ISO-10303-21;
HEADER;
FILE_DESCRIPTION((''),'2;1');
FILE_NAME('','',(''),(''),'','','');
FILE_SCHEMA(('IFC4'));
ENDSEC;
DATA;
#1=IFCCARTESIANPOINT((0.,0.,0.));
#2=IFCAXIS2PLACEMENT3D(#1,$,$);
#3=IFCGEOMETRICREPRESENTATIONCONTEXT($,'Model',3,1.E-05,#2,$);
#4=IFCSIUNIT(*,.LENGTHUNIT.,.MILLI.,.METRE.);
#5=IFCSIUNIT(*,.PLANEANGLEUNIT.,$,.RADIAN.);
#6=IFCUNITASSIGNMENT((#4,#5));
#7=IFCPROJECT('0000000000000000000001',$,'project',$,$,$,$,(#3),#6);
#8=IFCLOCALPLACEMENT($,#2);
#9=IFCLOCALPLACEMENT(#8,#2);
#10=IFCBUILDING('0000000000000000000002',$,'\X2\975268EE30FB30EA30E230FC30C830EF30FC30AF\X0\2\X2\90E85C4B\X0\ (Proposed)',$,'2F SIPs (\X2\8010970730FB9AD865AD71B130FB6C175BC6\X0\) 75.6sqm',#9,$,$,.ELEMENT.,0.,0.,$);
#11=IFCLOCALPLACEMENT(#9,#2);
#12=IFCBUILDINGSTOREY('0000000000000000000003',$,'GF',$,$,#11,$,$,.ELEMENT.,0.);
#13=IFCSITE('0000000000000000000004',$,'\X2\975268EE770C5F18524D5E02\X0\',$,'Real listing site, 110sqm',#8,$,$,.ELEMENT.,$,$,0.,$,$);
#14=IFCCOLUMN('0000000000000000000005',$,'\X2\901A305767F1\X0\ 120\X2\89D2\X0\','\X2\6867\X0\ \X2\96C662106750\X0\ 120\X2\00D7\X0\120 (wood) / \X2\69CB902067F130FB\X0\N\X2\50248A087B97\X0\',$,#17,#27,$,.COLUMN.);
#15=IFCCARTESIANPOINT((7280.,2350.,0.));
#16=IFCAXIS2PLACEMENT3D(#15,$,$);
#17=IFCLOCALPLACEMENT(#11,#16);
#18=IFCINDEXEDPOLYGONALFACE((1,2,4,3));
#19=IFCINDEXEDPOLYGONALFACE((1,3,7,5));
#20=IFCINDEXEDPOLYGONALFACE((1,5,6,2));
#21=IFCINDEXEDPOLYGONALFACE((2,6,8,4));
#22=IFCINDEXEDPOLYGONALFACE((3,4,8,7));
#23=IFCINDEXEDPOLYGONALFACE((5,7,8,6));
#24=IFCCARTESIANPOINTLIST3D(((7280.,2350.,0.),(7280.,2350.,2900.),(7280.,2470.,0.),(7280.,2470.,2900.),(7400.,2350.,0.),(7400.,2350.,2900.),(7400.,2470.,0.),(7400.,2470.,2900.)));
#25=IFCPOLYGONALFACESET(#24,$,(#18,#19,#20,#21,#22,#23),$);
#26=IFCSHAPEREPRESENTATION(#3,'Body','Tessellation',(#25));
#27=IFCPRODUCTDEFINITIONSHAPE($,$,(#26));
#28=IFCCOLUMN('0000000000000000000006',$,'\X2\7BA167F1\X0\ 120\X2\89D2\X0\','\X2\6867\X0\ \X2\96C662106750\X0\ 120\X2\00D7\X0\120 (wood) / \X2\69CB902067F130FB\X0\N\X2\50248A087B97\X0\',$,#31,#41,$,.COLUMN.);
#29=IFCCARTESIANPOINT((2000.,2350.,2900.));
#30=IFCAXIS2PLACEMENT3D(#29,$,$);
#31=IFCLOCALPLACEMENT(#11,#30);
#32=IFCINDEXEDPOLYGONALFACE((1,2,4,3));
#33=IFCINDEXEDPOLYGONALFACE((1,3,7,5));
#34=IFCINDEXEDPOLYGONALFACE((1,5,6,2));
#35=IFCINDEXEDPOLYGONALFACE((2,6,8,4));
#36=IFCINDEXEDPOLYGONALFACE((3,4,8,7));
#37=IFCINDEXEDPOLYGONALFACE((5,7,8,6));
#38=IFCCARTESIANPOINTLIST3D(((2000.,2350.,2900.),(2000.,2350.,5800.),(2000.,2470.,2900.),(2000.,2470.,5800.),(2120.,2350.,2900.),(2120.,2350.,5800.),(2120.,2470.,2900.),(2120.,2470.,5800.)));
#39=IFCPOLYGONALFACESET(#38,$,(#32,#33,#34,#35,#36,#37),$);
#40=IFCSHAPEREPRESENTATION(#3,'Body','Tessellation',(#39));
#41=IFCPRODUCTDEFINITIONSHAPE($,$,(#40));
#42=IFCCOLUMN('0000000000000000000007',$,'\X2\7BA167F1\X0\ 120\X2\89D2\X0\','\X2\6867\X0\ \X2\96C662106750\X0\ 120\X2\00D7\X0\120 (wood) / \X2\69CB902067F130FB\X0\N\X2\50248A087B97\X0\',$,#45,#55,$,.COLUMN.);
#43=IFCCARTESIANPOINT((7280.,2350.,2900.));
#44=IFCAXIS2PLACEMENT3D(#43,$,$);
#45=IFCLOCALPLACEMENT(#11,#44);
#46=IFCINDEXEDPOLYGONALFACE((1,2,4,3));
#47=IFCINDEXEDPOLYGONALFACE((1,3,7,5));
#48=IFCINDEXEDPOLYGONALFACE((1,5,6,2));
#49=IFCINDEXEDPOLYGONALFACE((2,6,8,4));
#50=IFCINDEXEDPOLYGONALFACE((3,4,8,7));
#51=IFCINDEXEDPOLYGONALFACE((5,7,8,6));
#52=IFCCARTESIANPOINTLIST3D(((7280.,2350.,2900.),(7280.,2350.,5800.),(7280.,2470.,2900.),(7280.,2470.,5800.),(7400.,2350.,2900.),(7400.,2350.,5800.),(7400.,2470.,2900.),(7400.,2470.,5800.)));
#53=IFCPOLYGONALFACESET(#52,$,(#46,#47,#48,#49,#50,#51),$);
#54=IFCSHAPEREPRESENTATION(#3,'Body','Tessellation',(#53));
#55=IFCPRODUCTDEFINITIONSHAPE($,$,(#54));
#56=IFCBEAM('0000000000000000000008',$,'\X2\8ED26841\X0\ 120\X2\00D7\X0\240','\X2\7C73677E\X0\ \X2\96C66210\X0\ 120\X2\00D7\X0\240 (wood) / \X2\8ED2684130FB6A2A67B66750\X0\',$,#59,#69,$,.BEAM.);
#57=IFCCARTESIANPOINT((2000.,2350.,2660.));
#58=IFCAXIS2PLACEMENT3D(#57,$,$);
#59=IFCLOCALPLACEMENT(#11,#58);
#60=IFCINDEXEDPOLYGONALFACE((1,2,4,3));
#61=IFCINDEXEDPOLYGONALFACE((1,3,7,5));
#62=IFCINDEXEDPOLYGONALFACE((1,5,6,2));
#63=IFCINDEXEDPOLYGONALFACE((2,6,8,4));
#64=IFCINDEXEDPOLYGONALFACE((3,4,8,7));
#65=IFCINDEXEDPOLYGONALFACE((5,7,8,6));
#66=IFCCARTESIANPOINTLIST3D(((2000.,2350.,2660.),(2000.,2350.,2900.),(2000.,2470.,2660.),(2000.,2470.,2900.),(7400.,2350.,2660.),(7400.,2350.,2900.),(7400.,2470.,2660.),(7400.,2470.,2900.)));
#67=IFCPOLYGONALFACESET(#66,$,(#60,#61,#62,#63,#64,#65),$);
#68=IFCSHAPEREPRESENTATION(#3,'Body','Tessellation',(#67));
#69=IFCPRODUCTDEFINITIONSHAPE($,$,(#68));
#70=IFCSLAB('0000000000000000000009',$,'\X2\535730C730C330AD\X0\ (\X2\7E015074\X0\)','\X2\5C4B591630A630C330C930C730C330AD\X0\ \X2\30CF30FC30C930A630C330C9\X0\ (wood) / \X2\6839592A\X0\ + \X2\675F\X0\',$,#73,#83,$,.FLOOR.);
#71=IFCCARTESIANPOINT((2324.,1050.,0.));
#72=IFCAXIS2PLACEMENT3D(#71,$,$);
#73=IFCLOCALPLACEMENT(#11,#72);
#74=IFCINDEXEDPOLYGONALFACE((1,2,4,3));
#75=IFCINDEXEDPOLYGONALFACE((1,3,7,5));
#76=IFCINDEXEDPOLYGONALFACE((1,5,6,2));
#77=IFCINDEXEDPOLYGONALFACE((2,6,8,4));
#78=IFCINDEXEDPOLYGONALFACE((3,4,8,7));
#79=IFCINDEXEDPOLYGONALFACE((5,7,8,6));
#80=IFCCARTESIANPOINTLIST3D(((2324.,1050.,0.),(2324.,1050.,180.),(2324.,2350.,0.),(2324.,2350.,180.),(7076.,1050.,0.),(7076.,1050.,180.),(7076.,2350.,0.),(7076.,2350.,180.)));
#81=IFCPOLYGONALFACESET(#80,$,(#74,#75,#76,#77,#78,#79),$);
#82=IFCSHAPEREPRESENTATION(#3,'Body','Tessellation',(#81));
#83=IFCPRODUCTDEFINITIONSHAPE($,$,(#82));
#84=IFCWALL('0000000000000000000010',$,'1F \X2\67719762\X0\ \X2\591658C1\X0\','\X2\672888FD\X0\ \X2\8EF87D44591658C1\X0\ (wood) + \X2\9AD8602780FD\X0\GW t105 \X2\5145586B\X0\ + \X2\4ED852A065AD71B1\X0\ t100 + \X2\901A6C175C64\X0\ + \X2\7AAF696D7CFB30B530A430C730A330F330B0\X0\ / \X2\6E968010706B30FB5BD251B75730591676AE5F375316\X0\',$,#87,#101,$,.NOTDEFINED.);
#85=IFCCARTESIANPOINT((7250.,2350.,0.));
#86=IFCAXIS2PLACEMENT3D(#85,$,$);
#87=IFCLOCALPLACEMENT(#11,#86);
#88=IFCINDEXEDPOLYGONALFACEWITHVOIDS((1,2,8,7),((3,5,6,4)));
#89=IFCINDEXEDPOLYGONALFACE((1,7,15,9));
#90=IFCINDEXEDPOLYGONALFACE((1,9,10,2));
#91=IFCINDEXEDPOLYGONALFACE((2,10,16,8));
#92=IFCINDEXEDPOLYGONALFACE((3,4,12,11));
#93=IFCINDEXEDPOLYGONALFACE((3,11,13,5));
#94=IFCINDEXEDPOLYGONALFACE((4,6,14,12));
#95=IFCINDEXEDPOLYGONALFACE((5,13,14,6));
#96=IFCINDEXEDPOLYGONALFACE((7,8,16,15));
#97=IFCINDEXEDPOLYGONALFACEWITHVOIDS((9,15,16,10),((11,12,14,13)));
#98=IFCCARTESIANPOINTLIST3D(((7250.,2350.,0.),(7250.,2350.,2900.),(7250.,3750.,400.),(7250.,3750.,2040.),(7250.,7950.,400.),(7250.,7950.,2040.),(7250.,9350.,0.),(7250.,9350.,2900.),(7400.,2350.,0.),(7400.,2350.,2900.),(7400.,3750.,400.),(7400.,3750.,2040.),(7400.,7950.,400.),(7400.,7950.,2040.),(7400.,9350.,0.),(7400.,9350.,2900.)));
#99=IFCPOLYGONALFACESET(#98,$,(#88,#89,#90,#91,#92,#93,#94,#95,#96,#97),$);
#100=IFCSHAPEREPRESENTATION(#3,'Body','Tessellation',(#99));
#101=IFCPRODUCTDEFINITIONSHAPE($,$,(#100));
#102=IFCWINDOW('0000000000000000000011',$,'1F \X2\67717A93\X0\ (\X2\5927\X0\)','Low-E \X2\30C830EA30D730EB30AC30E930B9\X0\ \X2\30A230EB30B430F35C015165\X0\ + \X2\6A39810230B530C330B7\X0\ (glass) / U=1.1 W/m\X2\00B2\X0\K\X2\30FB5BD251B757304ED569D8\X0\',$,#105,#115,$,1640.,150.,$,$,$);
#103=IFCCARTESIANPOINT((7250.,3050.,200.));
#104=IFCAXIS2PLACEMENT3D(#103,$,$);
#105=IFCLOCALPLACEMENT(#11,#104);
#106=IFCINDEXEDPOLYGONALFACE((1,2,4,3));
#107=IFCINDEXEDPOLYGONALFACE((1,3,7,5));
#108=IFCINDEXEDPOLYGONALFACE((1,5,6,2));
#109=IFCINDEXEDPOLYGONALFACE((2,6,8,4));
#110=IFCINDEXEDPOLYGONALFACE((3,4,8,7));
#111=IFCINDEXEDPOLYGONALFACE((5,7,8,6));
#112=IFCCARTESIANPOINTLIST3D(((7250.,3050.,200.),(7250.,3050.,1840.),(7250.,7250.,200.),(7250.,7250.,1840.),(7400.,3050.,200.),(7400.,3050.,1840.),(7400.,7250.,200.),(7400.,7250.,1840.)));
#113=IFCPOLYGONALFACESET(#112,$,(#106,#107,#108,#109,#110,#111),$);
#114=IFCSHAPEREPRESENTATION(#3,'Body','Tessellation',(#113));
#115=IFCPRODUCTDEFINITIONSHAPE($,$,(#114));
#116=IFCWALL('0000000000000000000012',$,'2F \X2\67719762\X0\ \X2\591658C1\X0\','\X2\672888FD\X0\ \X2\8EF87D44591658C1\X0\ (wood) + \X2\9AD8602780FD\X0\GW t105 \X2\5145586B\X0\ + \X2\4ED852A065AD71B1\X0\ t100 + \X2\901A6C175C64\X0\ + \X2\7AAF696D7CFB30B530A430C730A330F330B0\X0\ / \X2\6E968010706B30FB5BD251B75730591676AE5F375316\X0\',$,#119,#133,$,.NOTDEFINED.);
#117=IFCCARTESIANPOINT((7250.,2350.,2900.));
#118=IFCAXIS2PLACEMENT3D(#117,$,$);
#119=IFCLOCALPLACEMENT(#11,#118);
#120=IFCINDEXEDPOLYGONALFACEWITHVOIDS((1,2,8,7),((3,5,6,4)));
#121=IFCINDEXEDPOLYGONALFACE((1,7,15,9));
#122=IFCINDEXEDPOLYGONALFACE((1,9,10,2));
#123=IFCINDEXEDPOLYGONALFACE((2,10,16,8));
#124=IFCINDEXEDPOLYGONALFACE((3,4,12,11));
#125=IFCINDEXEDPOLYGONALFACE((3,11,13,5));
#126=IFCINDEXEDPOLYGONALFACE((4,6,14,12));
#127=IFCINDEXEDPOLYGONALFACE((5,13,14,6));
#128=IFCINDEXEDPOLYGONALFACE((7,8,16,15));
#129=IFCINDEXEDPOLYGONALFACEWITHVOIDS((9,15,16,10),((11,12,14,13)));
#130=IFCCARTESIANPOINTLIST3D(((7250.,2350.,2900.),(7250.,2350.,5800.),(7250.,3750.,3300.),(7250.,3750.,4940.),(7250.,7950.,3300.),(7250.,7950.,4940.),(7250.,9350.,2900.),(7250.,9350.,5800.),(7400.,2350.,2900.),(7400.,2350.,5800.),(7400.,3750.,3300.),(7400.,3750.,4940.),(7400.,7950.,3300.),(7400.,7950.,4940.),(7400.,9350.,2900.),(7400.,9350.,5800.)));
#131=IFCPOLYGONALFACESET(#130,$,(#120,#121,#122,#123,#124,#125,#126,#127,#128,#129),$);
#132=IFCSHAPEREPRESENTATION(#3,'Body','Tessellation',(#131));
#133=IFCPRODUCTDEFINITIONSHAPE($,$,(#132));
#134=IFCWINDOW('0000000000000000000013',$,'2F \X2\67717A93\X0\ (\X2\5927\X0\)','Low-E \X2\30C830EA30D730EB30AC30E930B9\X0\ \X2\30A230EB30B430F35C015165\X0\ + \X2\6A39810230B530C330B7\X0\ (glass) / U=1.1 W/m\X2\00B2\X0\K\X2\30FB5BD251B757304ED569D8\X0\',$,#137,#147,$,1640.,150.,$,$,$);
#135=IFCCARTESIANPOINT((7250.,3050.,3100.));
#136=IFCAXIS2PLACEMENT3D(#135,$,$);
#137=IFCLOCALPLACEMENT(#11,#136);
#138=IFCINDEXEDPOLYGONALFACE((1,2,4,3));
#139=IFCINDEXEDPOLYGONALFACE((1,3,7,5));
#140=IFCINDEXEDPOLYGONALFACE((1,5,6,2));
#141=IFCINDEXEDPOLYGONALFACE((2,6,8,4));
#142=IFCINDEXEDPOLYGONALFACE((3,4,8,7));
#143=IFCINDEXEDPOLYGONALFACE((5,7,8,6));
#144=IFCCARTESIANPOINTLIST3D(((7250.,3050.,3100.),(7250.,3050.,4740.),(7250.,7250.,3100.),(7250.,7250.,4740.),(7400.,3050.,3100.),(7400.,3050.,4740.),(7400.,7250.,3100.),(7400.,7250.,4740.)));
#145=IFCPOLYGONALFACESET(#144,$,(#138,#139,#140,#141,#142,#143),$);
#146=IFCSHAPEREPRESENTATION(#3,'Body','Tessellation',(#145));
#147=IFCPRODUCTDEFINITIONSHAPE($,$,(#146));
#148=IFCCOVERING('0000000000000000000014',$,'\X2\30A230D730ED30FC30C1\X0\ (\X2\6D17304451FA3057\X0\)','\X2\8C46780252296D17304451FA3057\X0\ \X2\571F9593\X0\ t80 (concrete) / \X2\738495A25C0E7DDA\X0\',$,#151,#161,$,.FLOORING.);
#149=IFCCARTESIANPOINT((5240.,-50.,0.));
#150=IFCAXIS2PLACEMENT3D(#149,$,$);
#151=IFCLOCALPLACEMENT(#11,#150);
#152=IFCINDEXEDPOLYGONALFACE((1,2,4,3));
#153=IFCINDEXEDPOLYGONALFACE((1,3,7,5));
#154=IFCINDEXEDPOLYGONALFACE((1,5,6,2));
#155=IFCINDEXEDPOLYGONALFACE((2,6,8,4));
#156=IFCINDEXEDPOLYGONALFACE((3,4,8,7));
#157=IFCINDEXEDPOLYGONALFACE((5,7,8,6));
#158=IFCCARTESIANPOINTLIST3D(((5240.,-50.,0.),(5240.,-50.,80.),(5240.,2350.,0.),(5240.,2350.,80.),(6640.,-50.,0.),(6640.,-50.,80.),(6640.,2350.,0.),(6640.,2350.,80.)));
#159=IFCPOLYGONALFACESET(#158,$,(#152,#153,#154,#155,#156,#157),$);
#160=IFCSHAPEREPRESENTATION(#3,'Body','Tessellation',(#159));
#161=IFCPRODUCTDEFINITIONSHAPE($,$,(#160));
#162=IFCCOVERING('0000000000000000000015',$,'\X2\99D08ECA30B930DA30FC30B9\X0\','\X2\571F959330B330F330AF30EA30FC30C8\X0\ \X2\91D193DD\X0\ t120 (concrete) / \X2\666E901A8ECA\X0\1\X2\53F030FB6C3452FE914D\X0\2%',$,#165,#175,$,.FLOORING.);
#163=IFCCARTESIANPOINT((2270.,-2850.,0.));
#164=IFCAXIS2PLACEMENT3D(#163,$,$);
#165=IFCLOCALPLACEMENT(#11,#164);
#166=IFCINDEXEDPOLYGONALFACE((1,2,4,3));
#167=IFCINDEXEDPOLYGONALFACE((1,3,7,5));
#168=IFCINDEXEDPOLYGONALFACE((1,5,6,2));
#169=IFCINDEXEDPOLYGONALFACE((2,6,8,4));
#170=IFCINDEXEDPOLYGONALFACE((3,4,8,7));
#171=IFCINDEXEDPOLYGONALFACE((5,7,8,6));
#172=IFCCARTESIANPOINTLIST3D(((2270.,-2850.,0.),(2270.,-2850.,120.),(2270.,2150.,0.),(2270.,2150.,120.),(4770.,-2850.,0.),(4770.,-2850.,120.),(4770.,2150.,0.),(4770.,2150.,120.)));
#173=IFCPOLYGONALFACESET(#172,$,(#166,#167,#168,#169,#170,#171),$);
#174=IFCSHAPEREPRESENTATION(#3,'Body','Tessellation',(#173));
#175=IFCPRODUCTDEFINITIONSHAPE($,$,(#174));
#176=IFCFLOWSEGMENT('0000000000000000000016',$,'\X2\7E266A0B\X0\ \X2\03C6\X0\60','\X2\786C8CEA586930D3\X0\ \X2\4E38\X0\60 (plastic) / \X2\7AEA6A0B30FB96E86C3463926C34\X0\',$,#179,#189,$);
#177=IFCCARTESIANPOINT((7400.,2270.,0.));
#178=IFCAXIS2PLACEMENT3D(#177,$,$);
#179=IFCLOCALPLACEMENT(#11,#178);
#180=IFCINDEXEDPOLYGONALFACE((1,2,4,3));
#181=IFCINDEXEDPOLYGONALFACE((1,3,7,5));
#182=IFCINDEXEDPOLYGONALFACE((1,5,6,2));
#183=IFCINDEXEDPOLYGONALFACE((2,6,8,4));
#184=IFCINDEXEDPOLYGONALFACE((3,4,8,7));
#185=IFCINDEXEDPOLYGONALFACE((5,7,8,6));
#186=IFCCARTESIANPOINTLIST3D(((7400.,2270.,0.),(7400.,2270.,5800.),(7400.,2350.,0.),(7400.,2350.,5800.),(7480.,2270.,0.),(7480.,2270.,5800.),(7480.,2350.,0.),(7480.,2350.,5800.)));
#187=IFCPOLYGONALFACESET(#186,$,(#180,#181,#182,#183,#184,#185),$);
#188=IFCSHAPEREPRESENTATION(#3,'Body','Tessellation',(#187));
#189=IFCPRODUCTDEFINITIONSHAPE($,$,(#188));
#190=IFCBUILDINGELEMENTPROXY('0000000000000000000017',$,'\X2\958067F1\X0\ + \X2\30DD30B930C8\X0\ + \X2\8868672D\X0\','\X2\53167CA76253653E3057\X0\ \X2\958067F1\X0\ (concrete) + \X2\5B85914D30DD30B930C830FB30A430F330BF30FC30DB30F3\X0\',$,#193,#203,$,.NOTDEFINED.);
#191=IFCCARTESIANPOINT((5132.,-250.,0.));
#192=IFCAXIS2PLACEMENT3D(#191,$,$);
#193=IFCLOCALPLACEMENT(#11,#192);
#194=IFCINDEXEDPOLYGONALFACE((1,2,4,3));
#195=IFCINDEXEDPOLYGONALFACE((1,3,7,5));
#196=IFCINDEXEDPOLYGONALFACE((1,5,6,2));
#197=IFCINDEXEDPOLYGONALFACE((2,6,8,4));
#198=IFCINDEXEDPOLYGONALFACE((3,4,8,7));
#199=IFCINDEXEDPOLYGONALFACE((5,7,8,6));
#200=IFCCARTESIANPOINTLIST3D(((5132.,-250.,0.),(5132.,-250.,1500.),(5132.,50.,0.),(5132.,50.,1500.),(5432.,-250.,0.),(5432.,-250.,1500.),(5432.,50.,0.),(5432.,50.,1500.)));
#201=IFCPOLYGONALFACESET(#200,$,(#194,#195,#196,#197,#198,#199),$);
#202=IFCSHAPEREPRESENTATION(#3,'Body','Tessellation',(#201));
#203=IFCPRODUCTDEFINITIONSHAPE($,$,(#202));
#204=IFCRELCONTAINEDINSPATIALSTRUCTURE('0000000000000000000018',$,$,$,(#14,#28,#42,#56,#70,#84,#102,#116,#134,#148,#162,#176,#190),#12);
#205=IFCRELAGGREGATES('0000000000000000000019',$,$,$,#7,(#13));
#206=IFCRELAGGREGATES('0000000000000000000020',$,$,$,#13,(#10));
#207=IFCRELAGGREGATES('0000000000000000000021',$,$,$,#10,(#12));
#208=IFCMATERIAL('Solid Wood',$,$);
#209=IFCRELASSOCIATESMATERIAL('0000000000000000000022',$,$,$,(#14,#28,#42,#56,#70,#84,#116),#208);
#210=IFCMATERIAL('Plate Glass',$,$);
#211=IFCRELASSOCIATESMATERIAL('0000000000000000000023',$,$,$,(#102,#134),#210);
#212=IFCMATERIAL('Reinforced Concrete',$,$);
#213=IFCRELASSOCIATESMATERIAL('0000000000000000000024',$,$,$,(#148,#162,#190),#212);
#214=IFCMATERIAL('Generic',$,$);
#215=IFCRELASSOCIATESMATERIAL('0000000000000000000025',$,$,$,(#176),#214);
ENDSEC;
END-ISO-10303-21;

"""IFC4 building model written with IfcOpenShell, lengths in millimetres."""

from ifc_helpers import new_model, si_unit, frame, frame_2d, origin, place, context, project, spatial, rectangle, extrude, material, element, fill, save


model = new_model("IFC4")

# Units and contexts
model_context = context("Model", 3, precision=1e-05, world=origin())
ifc_project = project(units=[si_unit("LENGTHUNIT", "METRE", prefix="MILLI"), si_unit("PLANEANGLEUNIT", "RADIAN")], contexts=[model_context])

# Site, building, storey
site_placement = place(None, origin())
site = spatial("IfcSite", under=ifc_project, at=site_placement, Name="青森県弘前市", ObjectType="Real listing site, 110sqm", CompositionType="ELEMENT", RefElevation=0.0)
building_placement = place(site_placement, origin())
building = spatial("IfcBuilding", under=site, at=building_placement, Name="青森・リモートワーク2部屋 (Proposed)", ObjectType="2F SIPs (耐震・高断熱・気密) 75.6sqm", CompositionType="ELEMENT", ElevationOfRefHeight=0.0, ElevationOfTerrain=0.0)
storey_placement = place(building_placement, origin())
storey = spatial("IfcBuildingStorey", under=building, at=storey_placement, Name="GF", CompositionType="ELEMENT", Elevation=0.0)

# Columns
ifc_material_1 = material(Name="Solid Wood")
column_1_placement = place(storey_placement, frame((7280.0, 2350.0, 0.0)))
element("IfcColumn", 1, at=column_1_placement, inside=storey, material=ifc_material_1, Name="通し柱 120角", Description="桧 集成材 120×120 (wood) / 構造柱・N値計算", PredefinedType="COLUMN", context=model_context, shape_type="SweptSolid", body=[
    extrude(rectangle(XDim=120.0, YDim=120.0, at=frame_2d((60.0, 60.0))), frame((7280.0, 2350.0, 0.0)), (0.0, 0.0, 1.0), 2900.0),
])
column_2_placement = place(storey_placement, frame((2000.0, 2350.0, 2900.0)))
element("IfcColumn", 2, at=column_2_placement, inside=storey, material=ifc_material_1, Name="管柱 120角", Description="桧 集成材 120×120 (wood) / 構造柱・N値計算", PredefinedType="COLUMN", context=model_context, shape_type="SweptSolid", body=[
    extrude(rectangle(XDim=120.0, YDim=120.0, at=frame_2d((60.0, 60.0))), frame((2000.0, 2350.0, 2900.0)), (0.0, 0.0, 1.0), 2900.0),
])
column_3_placement = place(storey_placement, frame((7280.0, 2350.0, 2900.0)))
element("IfcColumn", 3, at=column_3_placement, inside=storey, material=ifc_material_1, Name="管柱 120角", Description="桧 集成材 120×120 (wood) / 構造柱・N値計算", PredefinedType="COLUMN", context=model_context, shape_type="SweptSolid", body=[
    extrude(rectangle(XDim=120.0, YDim=120.0, at=frame_2d((60.0, 60.0))), frame((7280.0, 2350.0, 2900.0)), (0.0, 0.0, 1.0), 2900.0),
])

# Beam
beam_1_placement = place(storey_placement, frame((2000.0, 2350.0, 2660.0)))
element("IfcBeam", 4, at=beam_1_placement, inside=storey, material=ifc_material_1, Name="軒桁 120×240", Description="米松 集成 120×240 (wood) / 軒桁・横架材", PredefinedType="BEAM", context=model_context, shape_type="SweptSolid", body=[
    extrude(rectangle(XDim=5400.0, YDim=120.0, at=frame_2d((2700.0, 60.0))), frame((2000.0, 2350.0, 2660.0)), (0.0, 0.0, 1.0), 240.0),
])

# Slab
slab_placement = place(storey_placement, frame((2324.0, 1050.0, 0.0)))
element("IfcSlab", 5, at=slab_placement, inside=storey, material=ifc_material_1, Name="南デッキ (縁側)", Description="屋外ウッドデッキ ハードウッド (wood) / 根太 + 束", PredefinedType="FLOOR", context=model_context, shape_type="SweptSolid", body=[
    extrude(rectangle(XDim=4752.0, YDim=1300.0, at=frame_2d((2376.0, 650.0))), frame((2324.0, 1050.0, 0.0)), (0.0, 0.0, 1.0), 180.0),
])

# Walls, openings, windows
wall_1_placement = place(storey_placement, frame((7250.0, 2350.0, 0.0)))
wall_1 = element("IfcWall", 6, at=wall_1_placement, inside=storey, material=ifc_material_1, Name="1F 東面 外壁", Description="木製 軸組外壁 (wood) + 高性能GW t105 充填 + 付加断熱 t100 + 通気層 + 窯業系サイディング / 準耐火・寒冷地外皮強化", PredefinedType="NOTDEFINED", context=model_context, shape_type="SweptSolid", body=[
    extrude(rectangle(XDim=150.0, YDim=7000.0, at=frame_2d((75.0, 3500.0))), frame((7250.0, 2350.0, 0.0)), (0.0, 0.0, 1.0), 2900.0),
])
opening_1_placement = place(storey_placement, frame((7250.0, 3050.0, 200.0)))
opening_1 = element("IfcOpeningElement", 7, at=opening_1_placement, cuts=wall_1, PredefinedType="NOTDEFINED", context=model_context, shape_type="SweptSolid", body=[
    extrude(rectangle(XDim=150.0, YDim=4200.0, at=frame_2d((75.0, 2100.0))), frame((7250.0, 3050.0, 200.0)), (0.0, 0.0, 1.0), 1640.0),
])
ifc_material_2 = material(Name="Plate Glass")
window_1_placement = place(storey_placement, frame((7250.0, 3050.0, 200.0)))
window_1 = element("IfcWindow", 8, at=window_1_placement, inside=storey, material=ifc_material_2, Name="1F 東窓 (大)", Description="Low-E トリプルガラス アルゴン封入 + 樹脂サッシ (glass) / U=1.1 W/m²K・寒冷地仕様", OverallHeight=1640.0, OverallWidth=150.0, context=model_context, shape_type="SweptSolid", body=[
    extrude(rectangle(XDim=150.0, YDim=4200.0, at=frame_2d((75.0, 2100.0))), frame((7250.0, 3050.0, 200.0)), (0.0, 0.0, 1.0), 1640.0),
])
fill(opening_1, window_1)
wall_2_placement = place(storey_placement, frame((7250.0, 2350.0, 2900.0)))
wall_2 = element("IfcWall", 9, at=wall_2_placement, inside=storey, material=ifc_material_1, Name="2F 東面 外壁", Description="木製 軸組外壁 (wood) + 高性能GW t105 充填 + 付加断熱 t100 + 通気層 + 窯業系サイディング / 準耐火・寒冷地外皮強化", PredefinedType="NOTDEFINED", context=model_context, shape_type="SweptSolid", body=[
    extrude(rectangle(XDim=150.0, YDim=7000.0, at=frame_2d((75.0, 3500.0))), frame((7250.0, 2350.0, 2900.0)), (0.0, 0.0, 1.0), 2900.0),
])
opening_2_placement = place(storey_placement, frame((7250.0, 3050.0, 3100.0)))
opening_2 = element("IfcOpeningElement", 10, at=opening_2_placement, cuts=wall_2, PredefinedType="NOTDEFINED", context=model_context, shape_type="SweptSolid", body=[
    extrude(rectangle(XDim=150.0, YDim=4200.0, at=frame_2d((75.0, 2100.0))), frame((7250.0, 3050.0, 3100.0)), (0.0, 0.0, 1.0), 1640.0),
])
window_2_placement = place(storey_placement, frame((7250.0, 3050.0, 3100.0)))
window_2 = element("IfcWindow", 11, at=window_2_placement, inside=storey, material=ifc_material_2, Name="2F 東窓 (大)", Description="Low-E トリプルガラス アルゴン封入 + 樹脂サッシ (glass) / U=1.1 W/m²K・寒冷地仕様", OverallHeight=1640.0, OverallWidth=150.0, context=model_context, shape_type="SweptSolid", body=[
    extrude(rectangle(XDim=150.0, YDim=4200.0, at=frame_2d((75.0, 2100.0))), frame((7250.0, 3050.0, 3100.0)), (0.0, 0.0, 1.0), 1640.0),
])
fill(opening_2, window_2)

# Coverings
ifc_material_3 = material(Name="Reinforced Concrete")
covering_1_placement = place(storey_placement, frame((5240.0, -50.0, 0.0)))
element("IfcCovering", 12, at=covering_1_placement, inside=storey, material=ifc_material_3, Name="アプローチ (洗い出し)", Description="豆砂利洗い出し 土間 t80 (concrete) / 玄関導線", PredefinedType="FLOORING", context=model_context, shape_type="SweptSolid", body=[
    extrude(rectangle(XDim=1400.0, YDim=2400.0, at=frame_2d((700.0, 1200.0))), frame((5240.0, -50.0, 0.0)), (0.0, 0.0, 1.0), 80.0),
])
covering_2_placement = place(storey_placement, frame((2270.0, -2850.0, 0.0)))
element("IfcCovering", 13, at=covering_2_placement, inside=storey, material=ifc_material_3, Name="駐車スペース", Description="土間コンクリート 金鏝 t120 (concrete) / 普通車1台・水勾配2%", PredefinedType="FLOORING", context=model_context, shape_type="SweptSolid", body=[
    extrude(rectangle(XDim=2500.0, YDim=5000.0, at=frame_2d((1250.0, 2500.0))), frame((2270.0, -2850.0, 0.0)), (0.0, 0.0, 1.0), 120.0),
])

# Flow segment
ifc_material_4 = material(Name="Generic")
flow_segment_placement = place(storey_placement, frame((7400.0, 2270.0, 0.0)))
element("IfcFlowSegment", 14, at=flow_segment_placement, inside=storey, material=ifc_material_4, Name="縦樋 φ60", Description="硬質塩ビ 丸60 (plastic) / 竪樋・雨水排水", context=model_context, shape_type="SweptSolid", body=[
    extrude(rectangle(XDim=80.0, YDim=80.0, at=frame_2d((40.0, 40.0))), frame((7400.0, 2270.0, 0.0)), (0.0, 0.0, 1.0), 5800.0),
])

# Building element proxy
proxy_placement = place(storey_placement, frame((5132.0, -250.0, 0.0)))
element("IfcBuildingElementProxy", 15, at=proxy_placement, inside=storey, material=ifc_material_3, Name="門柱 + ポスト + 表札", Description="化粧打放し 門柱 (concrete) + 宅配ポスト・インターホン", PredefinedType="NOTDEFINED", context=model_context, shape_type="SweptSolid", body=[
    extrude(rectangle(XDim=300.0, YDim=300.0, at=frame_2d((150.0, 150.0))), frame((5132.0, -250.0, 0.0)), (0.0, 0.0, 1.0), 1500.0),
])

save(model, "model.ifc")
